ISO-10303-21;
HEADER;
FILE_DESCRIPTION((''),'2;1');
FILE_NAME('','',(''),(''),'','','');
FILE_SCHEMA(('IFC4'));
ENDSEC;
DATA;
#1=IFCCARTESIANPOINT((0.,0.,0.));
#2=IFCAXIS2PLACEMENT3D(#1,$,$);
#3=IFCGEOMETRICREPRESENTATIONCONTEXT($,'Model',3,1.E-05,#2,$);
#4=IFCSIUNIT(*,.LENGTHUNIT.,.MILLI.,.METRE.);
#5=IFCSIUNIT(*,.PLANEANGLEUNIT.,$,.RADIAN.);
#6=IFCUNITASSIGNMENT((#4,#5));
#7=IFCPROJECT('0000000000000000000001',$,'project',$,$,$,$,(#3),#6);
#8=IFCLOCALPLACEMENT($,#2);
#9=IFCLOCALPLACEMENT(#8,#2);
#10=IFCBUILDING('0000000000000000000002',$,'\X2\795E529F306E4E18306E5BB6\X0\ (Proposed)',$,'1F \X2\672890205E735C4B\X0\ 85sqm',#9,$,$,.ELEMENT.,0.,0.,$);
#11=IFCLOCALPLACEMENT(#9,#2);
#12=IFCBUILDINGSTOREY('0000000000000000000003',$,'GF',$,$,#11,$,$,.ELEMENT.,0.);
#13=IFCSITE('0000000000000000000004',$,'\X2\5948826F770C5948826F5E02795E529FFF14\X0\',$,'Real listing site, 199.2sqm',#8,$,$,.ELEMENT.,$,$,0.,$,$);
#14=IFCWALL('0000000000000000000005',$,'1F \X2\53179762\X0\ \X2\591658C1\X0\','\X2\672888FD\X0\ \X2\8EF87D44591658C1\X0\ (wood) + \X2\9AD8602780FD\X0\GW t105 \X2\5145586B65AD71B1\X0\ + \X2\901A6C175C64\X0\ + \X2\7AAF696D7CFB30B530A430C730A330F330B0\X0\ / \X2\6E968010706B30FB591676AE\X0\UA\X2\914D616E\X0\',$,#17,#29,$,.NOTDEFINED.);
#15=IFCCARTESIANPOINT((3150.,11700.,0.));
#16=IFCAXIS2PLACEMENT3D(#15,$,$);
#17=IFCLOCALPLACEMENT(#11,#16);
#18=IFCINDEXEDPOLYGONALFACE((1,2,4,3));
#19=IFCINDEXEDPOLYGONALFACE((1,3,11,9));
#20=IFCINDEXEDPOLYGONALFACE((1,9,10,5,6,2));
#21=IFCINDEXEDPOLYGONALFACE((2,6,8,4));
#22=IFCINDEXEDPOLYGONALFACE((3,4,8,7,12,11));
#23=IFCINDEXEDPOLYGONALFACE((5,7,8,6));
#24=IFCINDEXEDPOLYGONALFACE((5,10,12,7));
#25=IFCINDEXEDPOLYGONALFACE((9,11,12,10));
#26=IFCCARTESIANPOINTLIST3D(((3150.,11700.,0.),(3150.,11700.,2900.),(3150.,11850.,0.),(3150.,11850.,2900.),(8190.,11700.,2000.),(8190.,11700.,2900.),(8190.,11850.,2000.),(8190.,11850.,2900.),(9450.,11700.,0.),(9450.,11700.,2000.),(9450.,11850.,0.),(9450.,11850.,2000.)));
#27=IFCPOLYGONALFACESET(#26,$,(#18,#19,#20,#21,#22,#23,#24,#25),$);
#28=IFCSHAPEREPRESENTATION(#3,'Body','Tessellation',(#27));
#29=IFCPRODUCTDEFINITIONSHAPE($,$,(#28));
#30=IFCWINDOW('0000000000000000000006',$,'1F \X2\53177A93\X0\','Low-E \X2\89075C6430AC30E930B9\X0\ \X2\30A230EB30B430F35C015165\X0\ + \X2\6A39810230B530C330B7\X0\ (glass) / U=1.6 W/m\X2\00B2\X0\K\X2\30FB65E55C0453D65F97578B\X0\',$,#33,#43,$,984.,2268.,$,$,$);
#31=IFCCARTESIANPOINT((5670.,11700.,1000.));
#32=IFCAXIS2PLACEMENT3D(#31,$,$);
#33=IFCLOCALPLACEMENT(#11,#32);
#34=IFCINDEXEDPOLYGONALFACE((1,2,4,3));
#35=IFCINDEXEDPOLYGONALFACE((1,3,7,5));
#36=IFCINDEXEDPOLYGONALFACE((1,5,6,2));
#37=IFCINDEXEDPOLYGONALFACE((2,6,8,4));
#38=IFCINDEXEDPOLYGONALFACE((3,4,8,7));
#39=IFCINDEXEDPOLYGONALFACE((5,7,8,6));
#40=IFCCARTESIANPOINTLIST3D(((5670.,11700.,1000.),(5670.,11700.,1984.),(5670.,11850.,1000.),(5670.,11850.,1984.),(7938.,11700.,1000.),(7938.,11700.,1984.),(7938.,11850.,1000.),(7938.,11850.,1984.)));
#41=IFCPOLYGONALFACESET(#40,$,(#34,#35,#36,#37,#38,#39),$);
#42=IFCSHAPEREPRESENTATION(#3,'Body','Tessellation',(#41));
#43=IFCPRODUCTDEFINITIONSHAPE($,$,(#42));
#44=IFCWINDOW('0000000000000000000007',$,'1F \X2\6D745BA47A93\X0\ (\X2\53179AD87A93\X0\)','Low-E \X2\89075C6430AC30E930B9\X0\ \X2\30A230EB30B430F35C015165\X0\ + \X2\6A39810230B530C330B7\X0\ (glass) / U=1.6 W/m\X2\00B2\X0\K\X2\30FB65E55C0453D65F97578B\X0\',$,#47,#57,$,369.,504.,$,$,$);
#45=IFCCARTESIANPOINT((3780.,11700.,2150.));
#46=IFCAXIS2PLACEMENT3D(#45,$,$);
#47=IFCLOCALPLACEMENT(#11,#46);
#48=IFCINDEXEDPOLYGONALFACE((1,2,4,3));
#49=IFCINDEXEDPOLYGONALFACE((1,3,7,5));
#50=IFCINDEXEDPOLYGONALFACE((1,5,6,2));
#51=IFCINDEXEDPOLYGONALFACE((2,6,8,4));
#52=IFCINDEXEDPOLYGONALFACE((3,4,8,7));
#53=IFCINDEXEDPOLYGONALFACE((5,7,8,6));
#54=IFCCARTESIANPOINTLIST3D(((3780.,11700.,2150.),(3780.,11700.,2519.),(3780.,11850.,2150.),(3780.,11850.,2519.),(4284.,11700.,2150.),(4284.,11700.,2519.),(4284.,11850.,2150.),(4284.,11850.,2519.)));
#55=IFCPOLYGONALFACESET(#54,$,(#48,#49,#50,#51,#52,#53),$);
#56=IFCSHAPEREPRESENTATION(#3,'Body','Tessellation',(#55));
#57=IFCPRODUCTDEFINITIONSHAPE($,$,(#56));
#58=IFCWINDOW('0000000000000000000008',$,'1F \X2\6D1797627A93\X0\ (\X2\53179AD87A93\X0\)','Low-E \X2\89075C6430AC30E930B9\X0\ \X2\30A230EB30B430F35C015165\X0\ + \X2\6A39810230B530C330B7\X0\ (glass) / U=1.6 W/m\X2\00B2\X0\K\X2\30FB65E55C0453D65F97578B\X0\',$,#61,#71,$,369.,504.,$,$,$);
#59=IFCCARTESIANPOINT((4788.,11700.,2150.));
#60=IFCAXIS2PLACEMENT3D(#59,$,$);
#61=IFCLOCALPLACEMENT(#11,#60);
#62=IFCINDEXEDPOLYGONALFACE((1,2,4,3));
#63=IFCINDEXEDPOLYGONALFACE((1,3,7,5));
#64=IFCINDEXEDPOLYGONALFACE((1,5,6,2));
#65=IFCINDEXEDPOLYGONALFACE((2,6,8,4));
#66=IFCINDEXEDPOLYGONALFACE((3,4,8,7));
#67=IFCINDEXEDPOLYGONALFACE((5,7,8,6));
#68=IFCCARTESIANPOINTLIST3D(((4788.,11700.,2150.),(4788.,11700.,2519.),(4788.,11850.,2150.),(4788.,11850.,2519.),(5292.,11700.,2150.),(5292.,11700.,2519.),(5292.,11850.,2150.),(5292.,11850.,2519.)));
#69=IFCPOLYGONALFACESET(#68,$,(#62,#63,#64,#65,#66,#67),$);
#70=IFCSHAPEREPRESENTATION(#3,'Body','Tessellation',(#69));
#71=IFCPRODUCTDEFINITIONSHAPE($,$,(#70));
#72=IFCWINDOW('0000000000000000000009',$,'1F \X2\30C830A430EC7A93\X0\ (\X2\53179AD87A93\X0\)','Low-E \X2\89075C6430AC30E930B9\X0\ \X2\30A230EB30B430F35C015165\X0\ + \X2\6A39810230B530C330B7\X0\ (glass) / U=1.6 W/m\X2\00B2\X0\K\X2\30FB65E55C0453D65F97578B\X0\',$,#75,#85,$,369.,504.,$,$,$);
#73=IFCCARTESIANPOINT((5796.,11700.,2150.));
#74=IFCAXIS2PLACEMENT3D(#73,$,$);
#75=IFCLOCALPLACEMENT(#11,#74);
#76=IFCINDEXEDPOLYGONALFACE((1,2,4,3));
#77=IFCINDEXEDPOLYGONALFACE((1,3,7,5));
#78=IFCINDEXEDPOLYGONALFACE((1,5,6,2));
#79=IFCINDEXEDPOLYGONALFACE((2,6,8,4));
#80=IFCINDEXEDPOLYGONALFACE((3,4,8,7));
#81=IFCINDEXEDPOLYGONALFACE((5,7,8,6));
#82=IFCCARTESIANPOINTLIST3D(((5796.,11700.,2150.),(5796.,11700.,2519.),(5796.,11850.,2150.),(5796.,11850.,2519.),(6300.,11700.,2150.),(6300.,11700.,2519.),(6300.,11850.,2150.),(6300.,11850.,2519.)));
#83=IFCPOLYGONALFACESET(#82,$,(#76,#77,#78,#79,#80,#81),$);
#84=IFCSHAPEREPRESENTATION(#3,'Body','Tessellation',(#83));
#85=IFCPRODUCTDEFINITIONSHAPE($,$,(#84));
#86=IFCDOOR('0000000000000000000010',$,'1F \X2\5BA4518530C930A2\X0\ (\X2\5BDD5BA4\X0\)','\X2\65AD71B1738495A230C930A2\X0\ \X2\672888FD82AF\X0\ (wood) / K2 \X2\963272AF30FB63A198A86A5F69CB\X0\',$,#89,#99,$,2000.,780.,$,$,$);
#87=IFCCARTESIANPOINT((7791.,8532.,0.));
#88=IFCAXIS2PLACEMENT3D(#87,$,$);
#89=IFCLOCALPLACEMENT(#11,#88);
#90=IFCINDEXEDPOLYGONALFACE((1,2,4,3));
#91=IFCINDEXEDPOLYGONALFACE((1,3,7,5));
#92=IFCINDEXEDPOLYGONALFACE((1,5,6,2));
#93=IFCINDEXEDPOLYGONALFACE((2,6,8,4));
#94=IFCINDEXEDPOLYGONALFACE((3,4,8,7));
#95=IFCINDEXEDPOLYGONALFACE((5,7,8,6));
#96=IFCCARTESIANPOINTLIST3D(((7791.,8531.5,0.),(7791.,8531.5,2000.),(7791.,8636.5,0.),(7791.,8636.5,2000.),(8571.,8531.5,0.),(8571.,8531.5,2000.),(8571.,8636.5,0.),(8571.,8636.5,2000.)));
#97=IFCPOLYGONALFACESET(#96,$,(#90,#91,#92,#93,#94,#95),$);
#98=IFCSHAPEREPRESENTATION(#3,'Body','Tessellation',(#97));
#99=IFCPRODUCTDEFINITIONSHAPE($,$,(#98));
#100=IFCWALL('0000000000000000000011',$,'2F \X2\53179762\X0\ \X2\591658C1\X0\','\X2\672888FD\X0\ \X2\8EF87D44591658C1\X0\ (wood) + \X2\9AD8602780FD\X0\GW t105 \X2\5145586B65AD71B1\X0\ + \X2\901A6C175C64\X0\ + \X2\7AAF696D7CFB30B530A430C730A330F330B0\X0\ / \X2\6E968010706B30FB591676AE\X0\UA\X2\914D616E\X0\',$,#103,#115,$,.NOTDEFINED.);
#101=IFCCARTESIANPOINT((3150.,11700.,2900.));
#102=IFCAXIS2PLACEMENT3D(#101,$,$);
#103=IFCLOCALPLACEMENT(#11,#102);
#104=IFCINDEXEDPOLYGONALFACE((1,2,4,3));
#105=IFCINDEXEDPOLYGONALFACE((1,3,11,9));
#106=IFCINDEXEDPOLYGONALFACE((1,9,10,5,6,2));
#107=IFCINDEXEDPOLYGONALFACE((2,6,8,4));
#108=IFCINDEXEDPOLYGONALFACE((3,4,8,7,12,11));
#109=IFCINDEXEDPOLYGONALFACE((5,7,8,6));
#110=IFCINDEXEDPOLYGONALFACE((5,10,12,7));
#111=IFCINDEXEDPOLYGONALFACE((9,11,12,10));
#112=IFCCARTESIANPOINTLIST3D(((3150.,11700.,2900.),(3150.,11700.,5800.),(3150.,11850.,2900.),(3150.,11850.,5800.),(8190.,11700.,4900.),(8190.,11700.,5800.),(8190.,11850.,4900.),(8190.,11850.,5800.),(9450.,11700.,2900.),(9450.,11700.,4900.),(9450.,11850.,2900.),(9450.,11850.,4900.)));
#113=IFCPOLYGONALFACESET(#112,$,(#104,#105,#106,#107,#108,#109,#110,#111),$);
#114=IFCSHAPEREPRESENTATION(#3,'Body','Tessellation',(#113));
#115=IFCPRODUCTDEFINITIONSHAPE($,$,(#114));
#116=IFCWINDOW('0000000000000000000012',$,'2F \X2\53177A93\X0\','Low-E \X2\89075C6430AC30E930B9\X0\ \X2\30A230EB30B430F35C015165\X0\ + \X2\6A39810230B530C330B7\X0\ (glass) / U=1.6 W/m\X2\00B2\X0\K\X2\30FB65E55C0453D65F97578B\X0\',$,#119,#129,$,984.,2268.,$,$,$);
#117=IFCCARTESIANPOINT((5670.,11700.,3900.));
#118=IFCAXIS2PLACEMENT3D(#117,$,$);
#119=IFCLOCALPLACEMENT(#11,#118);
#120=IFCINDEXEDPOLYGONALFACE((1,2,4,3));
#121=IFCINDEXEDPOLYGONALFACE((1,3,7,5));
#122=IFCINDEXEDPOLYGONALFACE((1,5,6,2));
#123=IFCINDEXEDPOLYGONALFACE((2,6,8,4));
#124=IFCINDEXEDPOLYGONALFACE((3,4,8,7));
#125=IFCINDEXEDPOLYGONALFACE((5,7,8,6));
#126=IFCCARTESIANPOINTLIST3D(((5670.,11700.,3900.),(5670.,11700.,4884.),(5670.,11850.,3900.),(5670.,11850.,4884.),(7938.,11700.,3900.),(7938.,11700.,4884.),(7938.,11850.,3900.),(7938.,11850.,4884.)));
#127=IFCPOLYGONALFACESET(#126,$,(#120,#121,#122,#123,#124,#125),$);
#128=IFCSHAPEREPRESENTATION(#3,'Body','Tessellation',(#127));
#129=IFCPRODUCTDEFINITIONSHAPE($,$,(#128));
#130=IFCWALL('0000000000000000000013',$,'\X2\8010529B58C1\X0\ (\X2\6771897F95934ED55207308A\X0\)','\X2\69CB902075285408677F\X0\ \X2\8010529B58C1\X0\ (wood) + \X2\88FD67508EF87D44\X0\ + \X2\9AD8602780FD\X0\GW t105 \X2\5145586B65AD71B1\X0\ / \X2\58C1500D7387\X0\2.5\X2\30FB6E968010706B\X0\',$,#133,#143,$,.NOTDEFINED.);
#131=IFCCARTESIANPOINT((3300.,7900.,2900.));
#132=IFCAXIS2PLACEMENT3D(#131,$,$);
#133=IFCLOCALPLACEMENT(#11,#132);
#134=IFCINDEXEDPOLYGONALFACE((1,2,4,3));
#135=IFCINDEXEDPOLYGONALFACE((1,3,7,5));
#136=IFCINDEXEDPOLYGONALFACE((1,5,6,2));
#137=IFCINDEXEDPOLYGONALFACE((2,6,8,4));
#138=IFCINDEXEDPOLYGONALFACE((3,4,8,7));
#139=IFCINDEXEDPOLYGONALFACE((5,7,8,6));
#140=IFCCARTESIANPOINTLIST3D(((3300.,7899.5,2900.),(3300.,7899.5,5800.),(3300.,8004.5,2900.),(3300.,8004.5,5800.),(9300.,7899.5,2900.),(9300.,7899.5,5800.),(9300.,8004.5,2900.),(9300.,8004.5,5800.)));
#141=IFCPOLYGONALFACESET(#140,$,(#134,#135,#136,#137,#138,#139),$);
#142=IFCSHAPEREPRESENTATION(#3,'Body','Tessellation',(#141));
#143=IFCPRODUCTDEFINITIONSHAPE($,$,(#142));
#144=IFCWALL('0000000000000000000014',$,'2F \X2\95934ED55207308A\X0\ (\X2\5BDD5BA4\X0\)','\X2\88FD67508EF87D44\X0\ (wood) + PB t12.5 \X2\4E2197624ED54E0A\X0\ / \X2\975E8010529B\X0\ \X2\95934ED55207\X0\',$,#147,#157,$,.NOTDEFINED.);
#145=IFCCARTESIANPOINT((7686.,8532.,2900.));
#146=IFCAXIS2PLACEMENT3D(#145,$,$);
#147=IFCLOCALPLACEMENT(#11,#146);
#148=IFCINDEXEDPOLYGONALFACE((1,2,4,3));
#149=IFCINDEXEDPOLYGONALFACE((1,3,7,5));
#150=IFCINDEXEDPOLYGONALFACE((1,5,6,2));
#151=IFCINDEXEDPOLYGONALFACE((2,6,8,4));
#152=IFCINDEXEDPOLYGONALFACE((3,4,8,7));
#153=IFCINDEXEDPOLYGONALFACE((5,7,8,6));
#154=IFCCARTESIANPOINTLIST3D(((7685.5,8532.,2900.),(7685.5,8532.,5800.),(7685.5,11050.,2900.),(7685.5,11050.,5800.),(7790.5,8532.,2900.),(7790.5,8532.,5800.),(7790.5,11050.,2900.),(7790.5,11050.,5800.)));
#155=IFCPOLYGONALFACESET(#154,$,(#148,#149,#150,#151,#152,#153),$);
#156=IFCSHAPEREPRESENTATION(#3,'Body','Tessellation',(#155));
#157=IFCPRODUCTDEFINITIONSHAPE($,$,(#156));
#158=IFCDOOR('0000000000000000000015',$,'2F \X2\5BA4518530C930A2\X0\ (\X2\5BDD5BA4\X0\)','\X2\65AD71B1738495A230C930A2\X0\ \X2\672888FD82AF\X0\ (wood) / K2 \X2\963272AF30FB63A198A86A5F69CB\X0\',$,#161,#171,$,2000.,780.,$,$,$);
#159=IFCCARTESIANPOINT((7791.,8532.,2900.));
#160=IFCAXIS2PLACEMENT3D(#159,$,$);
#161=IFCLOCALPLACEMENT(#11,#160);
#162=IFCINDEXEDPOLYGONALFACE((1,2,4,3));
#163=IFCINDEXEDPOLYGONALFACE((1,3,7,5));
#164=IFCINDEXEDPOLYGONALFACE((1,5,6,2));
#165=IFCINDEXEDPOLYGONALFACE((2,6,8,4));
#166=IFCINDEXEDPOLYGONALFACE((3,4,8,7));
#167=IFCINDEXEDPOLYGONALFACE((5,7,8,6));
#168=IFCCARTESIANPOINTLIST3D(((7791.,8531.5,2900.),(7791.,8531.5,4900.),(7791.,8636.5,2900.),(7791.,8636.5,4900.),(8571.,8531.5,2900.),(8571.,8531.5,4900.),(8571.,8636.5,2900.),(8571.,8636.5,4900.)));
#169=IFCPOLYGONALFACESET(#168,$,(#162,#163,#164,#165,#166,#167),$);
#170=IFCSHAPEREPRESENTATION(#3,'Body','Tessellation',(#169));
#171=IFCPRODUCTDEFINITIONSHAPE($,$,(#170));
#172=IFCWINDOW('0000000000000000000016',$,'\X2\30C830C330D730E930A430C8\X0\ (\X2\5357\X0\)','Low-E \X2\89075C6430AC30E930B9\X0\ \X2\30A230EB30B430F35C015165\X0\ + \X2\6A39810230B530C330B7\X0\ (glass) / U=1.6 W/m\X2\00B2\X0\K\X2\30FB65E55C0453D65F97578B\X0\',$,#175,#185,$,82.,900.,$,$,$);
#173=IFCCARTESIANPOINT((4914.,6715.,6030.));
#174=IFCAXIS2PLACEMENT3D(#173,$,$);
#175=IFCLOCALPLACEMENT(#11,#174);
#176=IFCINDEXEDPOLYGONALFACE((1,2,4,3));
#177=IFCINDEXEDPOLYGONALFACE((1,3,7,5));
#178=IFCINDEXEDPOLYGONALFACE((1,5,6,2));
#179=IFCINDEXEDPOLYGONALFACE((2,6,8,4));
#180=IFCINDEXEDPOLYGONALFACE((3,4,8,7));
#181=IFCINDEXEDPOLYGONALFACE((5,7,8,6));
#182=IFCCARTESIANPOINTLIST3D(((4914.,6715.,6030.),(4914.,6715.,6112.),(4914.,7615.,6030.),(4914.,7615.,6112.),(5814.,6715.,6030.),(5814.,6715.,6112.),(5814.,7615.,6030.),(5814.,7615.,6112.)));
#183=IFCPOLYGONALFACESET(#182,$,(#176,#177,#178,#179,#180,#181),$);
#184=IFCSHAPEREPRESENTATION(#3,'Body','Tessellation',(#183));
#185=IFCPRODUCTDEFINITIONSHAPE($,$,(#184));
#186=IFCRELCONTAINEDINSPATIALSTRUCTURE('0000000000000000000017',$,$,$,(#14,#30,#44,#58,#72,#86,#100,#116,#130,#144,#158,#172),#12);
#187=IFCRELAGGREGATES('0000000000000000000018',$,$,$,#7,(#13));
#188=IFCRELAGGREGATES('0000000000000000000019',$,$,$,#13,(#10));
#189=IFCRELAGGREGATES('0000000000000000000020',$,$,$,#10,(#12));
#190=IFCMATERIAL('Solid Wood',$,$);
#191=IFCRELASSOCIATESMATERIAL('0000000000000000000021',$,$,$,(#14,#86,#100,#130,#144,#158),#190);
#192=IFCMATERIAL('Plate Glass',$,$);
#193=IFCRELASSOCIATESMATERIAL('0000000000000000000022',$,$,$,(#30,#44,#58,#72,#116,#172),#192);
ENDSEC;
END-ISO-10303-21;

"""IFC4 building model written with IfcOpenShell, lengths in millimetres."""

from ifc_helpers import new_model, si_unit, frame, frame_2d, origin, place, context, project, spatial, rectangle, extrude, material, element, fill, save


model = new_model("IFC4")

# Units and contexts
model_context = context("Model", 3, precision=1e-05, world=origin())
ifc_project = project(units=[si_unit("LENGTHUNIT", "METRE", prefix="MILLI"), si_unit("PLANEANGLEUNIT", "RADIAN")], contexts=[model_context])

# Site, building, storey
site_placement = place(None, origin())
site = spatial("IfcSite", under=ifc_project, at=site_placement, Name="奈良県奈良市神功４", ObjectType="Real listing site, 199.2sqm", CompositionType="ELEMENT", RefElevation=0.0)
building_placement = place(site_placement, origin())
building = spatial("IfcBuilding", under=site, at=building_placement, Name="神功の丘の家 (Proposed)", ObjectType="1F 木造平屋 85sqm", CompositionType="ELEMENT", ElevationOfRefHeight=0.0, ElevationOfTerrain=0.0)
storey_placement = place(building_placement, origin())
storey = spatial("IfcBuildingStorey", under=building, at=storey_placement, Name="GF", CompositionType="ELEMENT", Elevation=0.0)

# Wall, openings, windows
ifc_material_1 = material(Name="Solid Wood")
wall_1_placement = place(storey_placement, frame((3150.0, 11700.0, 0.0)))
wall_1 = element("IfcWall", 1, at=wall_1_placement, inside=storey, material=ifc_material_1, Name="1F 北面 外壁", Description="木製 軸組外壁 (wood) + 高性能GW t105 充填断熱 + 通気層 + 窯業系サイディング / 準耐火・外皮UA配慮", PredefinedType="NOTDEFINED", context=model_context, shape_type="SweptSolid", body=[
    extrude(rectangle(XDim=6300.0, YDim=150.0, at=frame_2d((3150.0, 75.0))), frame((3150.0, 11700.0, 0.0)), (0.0, 0.0, 1.0), 2900.0),
])
opening_1_placement = place(storey_placement, frame((5670.0, 11700.0, 1000.0)))
opening_1 = element("IfcOpeningElement", 2, at=opening_1_placement, cuts=wall_1, PredefinedType="NOTDEFINED", context=model_context, shape_type="SweptSolid", body=[
    extrude(rectangle(XDim=2268.0, YDim=150.0, at=frame_2d((1134.0, 75.0))), frame((5670.0, 11700.0, 1000.0)), (0.0, 0.0, 1.0), 984.0),
])
opening_2_placement = place(storey_placement, frame((3780.0, 11700.0, 2150.0)))
opening_2 = element("IfcOpeningElement", 3, at=opening_2_placement, cuts=wall_1, PredefinedType="NOTDEFINED", context=model_context, shape_type="SweptSolid", body=[
    extrude(rectangle(XDim=504.0, YDim=150.0, at=frame_2d((252.0, 75.0))), frame((3780.0, 11700.0, 2150.0)), (0.0, 0.0, 1.0), 369.0),
])
opening_3_placement = place(storey_placement, frame((4788.0, 11700.0, 2150.0)))
opening_3 = element("IfcOpeningElement", 4, at=opening_3_placement, cuts=wall_1, PredefinedType="NOTDEFINED", context=model_context, shape_type="SweptSolid", body=[
    extrude(rectangle(XDim=504.0, YDim=150.0, at=frame_2d((252.0, 75.0))), frame((4788.0, 11700.0, 2150.0)), (0.0, 0.0, 1.0), 369.0),
])
opening_4_placement = place(storey_placement, frame((5796.0, 11700.0, 2150.0)))
opening_4 = element("IfcOpeningElement", 5, at=opening_4_placement, cuts=wall_1, PredefinedType="NOTDEFINED", context=model_context, shape_type="SweptSolid", body=[
    extrude(rectangle(XDim=504.0, YDim=150.0, at=frame_2d((252.0, 75.0))), frame((5796.0, 11700.0, 2150.0)), (0.0, 0.0, 1.0), 369.0),
])
ifc_material_2 = material(Name="Plate Glass")
window_1_placement = place(storey_placement, frame((5670.0, 11700.0, 1000.0)))
window_1 = element("IfcWindow", 6, at=window_1_placement, inside=storey, material=ifc_material_2, Name="1F 北窓", Description="Low-E 複層ガラス アルゴン封入 + 樹脂サッシ (glass) / U=1.6 W/m²K・日射取得型", OverallHeight=984.0, OverallWidth=2268.0, context=model_context, shape_type="SweptSolid", body=[
    extrude(rectangle(XDim=2268.0, YDim=150.0, at=frame_2d((1134.0, 75.0))), frame((5670.0, 11700.0, 1000.0)), (0.0, 0.0, 1.0), 984.0),
])
fill(opening_1, window_1)
window_2_placement = place(storey_placement, frame((3780.0, 11700.0, 2150.0)))
window_2 = element("IfcWindow", 7, at=window_2_placement, inside=storey, material=ifc_material_2, Name="1F 浴室窓 (北高窓)", Description="Low-E 複層ガラス アルゴン封入 + 樹脂サッシ (glass) / U=1.6 W/m²K・日射取得型", OverallHeight=369.0, OverallWidth=504.0, context=model_context, shape_type="SweptSolid", body=[
    extrude(rectangle(XDim=504.0, YDim=150.0, at=frame_2d((252.0, 75.0))), frame((3780.0, 11700.0, 2150.0)), (0.0, 0.0, 1.0), 369.0),
])
fill(opening_2, window_2)
window_3_placement = place(storey_placement, frame((4788.0, 11700.0, 2150.0)))
window_3 = element("IfcWindow", 8, at=window_3_placement, inside=storey, material=ifc_material_2, Name="1F 洗面窓 (北高窓)", Description="Low-E 複層ガラス アルゴン封入 + 樹脂サッシ (glass) / U=1.6 W/m²K・日射取得型", OverallHeight=369.0, OverallWidth=504.0, context=model_context, shape_type="SweptSolid", body=[
    extrude(rectangle(XDim=504.0, YDim=150.0, at=frame_2d((252.0, 75.0))), frame((4788.0, 11700.0, 2150.0)), (0.0, 0.0, 1.0), 369.0),
])
fill(opening_3, window_3)
window_4_placement = place(storey_placement, frame((5796.0, 11700.0, 2150.0)))
window_4 = element("IfcWindow", 9, at=window_4_placement, inside=storey, material=ifc_material_2, Name="1F トイレ窓 (北高窓)", Description="Low-E 複層ガラス アルゴン封入 + 樹脂サッシ (glass) / U=1.6 W/m²K・日射取得型", OverallHeight=369.0, OverallWidth=504.0, context=model_context, shape_type="SweptSolid", body=[
    extrude(rectangle(XDim=504.0, YDim=150.0, at=frame_2d((252.0, 75.0))), frame((5796.0, 11700.0, 2150.0)), (0.0, 0.0, 1.0), 369.0),
])
fill(opening_4, window_4)

# Door
door_1_placement = place(storey_placement, frame((7791.0, 8532.0, 0.0)))
element("IfcDoor", 10, at=door_1_placement, inside=storey, material=ifc_material_1, Name="1F 室内ドア (寝室)", Description="断熱玄関ドア 木製芯 (wood) / K2 防犯・採風機構", OverallHeight=2000.0, OverallWidth=780.0, context=model_context, shape_type="SweptSolid", body=[
    extrude(rectangle(XDim=780.0, YDim=105.0, at=frame_2d((390.0, 52.0))), frame((7791.0, 8532.0, 0.0)), (0.0, 0.0, 1.0), 2000.0),
])

# Wall, opening, window
wall_2_placement = place(storey_placement, frame((3150.0, 11700.0, 2900.0)))
wall_2 = element("IfcWall", 11, at=wall_2_placement, inside=storey, material=ifc_material_1, Name="2F 北面 外壁", Description="木製 軸組外壁 (wood) + 高性能GW t105 充填断熱 + 通気層 + 窯業系サイディング / 準耐火・外皮UA配慮", PredefinedType="NOTDEFINED", context=model_context, shape_type="SweptSolid", body=[
    extrude(rectangle(XDim=6300.0, YDim=150.0, at=frame_2d((3150.0, 75.0))), frame((3150.0, 11700.0, 2900.0)), (0.0, 0.0, 1.0), 2900.0),
])
opening_5_placement = place(storey_placement, frame((5670.0, 11700.0, 3900.0)))
opening_5 = element("IfcOpeningElement", 12, at=opening_5_placement, cuts=wall_2, PredefinedType="NOTDEFINED", context=model_context, shape_type="SweptSolid", body=[
    extrude(rectangle(XDim=2268.0, YDim=150.0, at=frame_2d((1134.0, 75.0))), frame((5670.0, 11700.0, 3900.0)), (0.0, 0.0, 1.0), 984.0),
])
window_5_placement = place(storey_placement, frame((5670.0, 11700.0, 3900.0)))
window_5 = element("IfcWindow", 13, at=window_5_placement, inside=storey, material=ifc_material_2, Name="2F 北窓", Description="Low-E 複層ガラス アルゴン封入 + 樹脂サッシ (glass) / U=1.6 W/m²K・日射取得型", OverallHeight=984.0, OverallWidth=2268.0, context=model_context, shape_type="SweptSolid", body=[
    extrude(rectangle(XDim=2268.0, YDim=150.0, at=frame_2d((1134.0, 75.0))), frame((5670.0, 11700.0, 3900.0)), (0.0, 0.0, 1.0), 984.0),
])
fill(opening_5, window_5)

# Walls
wall_3_placement = place(storey_placement, frame((3300.0, 7900.0, 2900.0)))
element("IfcWall", 14, at=wall_3_placement, inside=storey, material=ifc_material_1, Name="耐力壁 (東西間仕切り)", Description="構造用合板 耐力壁 (wood) + 製材軸組 + 高性能GW t105 充填断熱 / 壁倍率2.5・準耐火", PredefinedType="NOTDEFINED", context=model_context, shape_type="SweptSolid", body=[
    extrude(rectangle(XDim=6000.0, YDim=105.0, at=frame_2d((3000.0, 52.0))), frame((3300.0, 7900.0, 2900.0)), (0.0, 0.0, 1.0), 2900.0),
])
wall_4_placement = place(storey_placement, frame((7686.0, 8532.0, 2900.0)))
element("IfcWall", 15, at=wall_4_placement, inside=storey, material=ifc_material_1, Name="2F 間仕切り (寝室)", Description="製材軸組 (wood) + PB t12.5 両面仕上 / 非耐力 間仕切", PredefinedType="NOTDEFINED", context=model_context, shape_type="SweptSolid", body=[
    extrude(rectangle(XDim=105.0, YDim=2518.0, at=frame_2d((52.0, 1259.0))), frame((7686.0, 8532.0, 2900.0)), (0.0, 0.0, 1.0), 2900.0),
])

# Door
door_2_placement = place(storey_placement, frame((7791.0, 8532.0, 2900.0)))
element("IfcDoor", 16, at=door_2_placement, inside=storey, material=ifc_material_1, Name="2F 室内ドア (寝室)", Description="断熱玄関ドア 木製芯 (wood) / K2 防犯・採風機構", OverallHeight=2000.0, OverallWidth=780.0, context=model_context, shape_type="SweptSolid", body=[
    extrude(rectangle(XDim=780.0, YDim=105.0, at=frame_2d((390.0, 52.0))), frame((7791.0, 8532.0, 2900.0)), (0.0, 0.0, 1.0), 2000.0),
])

# Window
window_6_placement = place(storey_placement, frame((4914.0, 6715.0, 6030.0)))
element("IfcWindow", 17, at=window_6_placement, inside=storey, material=ifc_material_2, Name="トップライト (南)", Description="Low-E 複層ガラス アルゴン封入 + 樹脂サッシ (glass) / U=1.6 W/m²K・日射取得型", OverallHeight=82.0, OverallWidth=900.0, context=model_context, shape_type="SweptSolid", body=[
    extrude(rectangle(XDim=900.0, YDim=900.0, at=frame_2d((450.0, 450.0))), frame((4914.0, 6715.0, 6030.0)), (0.0, 0.0, 1.0), 82.0),
])

save(model, "model.ifc")
